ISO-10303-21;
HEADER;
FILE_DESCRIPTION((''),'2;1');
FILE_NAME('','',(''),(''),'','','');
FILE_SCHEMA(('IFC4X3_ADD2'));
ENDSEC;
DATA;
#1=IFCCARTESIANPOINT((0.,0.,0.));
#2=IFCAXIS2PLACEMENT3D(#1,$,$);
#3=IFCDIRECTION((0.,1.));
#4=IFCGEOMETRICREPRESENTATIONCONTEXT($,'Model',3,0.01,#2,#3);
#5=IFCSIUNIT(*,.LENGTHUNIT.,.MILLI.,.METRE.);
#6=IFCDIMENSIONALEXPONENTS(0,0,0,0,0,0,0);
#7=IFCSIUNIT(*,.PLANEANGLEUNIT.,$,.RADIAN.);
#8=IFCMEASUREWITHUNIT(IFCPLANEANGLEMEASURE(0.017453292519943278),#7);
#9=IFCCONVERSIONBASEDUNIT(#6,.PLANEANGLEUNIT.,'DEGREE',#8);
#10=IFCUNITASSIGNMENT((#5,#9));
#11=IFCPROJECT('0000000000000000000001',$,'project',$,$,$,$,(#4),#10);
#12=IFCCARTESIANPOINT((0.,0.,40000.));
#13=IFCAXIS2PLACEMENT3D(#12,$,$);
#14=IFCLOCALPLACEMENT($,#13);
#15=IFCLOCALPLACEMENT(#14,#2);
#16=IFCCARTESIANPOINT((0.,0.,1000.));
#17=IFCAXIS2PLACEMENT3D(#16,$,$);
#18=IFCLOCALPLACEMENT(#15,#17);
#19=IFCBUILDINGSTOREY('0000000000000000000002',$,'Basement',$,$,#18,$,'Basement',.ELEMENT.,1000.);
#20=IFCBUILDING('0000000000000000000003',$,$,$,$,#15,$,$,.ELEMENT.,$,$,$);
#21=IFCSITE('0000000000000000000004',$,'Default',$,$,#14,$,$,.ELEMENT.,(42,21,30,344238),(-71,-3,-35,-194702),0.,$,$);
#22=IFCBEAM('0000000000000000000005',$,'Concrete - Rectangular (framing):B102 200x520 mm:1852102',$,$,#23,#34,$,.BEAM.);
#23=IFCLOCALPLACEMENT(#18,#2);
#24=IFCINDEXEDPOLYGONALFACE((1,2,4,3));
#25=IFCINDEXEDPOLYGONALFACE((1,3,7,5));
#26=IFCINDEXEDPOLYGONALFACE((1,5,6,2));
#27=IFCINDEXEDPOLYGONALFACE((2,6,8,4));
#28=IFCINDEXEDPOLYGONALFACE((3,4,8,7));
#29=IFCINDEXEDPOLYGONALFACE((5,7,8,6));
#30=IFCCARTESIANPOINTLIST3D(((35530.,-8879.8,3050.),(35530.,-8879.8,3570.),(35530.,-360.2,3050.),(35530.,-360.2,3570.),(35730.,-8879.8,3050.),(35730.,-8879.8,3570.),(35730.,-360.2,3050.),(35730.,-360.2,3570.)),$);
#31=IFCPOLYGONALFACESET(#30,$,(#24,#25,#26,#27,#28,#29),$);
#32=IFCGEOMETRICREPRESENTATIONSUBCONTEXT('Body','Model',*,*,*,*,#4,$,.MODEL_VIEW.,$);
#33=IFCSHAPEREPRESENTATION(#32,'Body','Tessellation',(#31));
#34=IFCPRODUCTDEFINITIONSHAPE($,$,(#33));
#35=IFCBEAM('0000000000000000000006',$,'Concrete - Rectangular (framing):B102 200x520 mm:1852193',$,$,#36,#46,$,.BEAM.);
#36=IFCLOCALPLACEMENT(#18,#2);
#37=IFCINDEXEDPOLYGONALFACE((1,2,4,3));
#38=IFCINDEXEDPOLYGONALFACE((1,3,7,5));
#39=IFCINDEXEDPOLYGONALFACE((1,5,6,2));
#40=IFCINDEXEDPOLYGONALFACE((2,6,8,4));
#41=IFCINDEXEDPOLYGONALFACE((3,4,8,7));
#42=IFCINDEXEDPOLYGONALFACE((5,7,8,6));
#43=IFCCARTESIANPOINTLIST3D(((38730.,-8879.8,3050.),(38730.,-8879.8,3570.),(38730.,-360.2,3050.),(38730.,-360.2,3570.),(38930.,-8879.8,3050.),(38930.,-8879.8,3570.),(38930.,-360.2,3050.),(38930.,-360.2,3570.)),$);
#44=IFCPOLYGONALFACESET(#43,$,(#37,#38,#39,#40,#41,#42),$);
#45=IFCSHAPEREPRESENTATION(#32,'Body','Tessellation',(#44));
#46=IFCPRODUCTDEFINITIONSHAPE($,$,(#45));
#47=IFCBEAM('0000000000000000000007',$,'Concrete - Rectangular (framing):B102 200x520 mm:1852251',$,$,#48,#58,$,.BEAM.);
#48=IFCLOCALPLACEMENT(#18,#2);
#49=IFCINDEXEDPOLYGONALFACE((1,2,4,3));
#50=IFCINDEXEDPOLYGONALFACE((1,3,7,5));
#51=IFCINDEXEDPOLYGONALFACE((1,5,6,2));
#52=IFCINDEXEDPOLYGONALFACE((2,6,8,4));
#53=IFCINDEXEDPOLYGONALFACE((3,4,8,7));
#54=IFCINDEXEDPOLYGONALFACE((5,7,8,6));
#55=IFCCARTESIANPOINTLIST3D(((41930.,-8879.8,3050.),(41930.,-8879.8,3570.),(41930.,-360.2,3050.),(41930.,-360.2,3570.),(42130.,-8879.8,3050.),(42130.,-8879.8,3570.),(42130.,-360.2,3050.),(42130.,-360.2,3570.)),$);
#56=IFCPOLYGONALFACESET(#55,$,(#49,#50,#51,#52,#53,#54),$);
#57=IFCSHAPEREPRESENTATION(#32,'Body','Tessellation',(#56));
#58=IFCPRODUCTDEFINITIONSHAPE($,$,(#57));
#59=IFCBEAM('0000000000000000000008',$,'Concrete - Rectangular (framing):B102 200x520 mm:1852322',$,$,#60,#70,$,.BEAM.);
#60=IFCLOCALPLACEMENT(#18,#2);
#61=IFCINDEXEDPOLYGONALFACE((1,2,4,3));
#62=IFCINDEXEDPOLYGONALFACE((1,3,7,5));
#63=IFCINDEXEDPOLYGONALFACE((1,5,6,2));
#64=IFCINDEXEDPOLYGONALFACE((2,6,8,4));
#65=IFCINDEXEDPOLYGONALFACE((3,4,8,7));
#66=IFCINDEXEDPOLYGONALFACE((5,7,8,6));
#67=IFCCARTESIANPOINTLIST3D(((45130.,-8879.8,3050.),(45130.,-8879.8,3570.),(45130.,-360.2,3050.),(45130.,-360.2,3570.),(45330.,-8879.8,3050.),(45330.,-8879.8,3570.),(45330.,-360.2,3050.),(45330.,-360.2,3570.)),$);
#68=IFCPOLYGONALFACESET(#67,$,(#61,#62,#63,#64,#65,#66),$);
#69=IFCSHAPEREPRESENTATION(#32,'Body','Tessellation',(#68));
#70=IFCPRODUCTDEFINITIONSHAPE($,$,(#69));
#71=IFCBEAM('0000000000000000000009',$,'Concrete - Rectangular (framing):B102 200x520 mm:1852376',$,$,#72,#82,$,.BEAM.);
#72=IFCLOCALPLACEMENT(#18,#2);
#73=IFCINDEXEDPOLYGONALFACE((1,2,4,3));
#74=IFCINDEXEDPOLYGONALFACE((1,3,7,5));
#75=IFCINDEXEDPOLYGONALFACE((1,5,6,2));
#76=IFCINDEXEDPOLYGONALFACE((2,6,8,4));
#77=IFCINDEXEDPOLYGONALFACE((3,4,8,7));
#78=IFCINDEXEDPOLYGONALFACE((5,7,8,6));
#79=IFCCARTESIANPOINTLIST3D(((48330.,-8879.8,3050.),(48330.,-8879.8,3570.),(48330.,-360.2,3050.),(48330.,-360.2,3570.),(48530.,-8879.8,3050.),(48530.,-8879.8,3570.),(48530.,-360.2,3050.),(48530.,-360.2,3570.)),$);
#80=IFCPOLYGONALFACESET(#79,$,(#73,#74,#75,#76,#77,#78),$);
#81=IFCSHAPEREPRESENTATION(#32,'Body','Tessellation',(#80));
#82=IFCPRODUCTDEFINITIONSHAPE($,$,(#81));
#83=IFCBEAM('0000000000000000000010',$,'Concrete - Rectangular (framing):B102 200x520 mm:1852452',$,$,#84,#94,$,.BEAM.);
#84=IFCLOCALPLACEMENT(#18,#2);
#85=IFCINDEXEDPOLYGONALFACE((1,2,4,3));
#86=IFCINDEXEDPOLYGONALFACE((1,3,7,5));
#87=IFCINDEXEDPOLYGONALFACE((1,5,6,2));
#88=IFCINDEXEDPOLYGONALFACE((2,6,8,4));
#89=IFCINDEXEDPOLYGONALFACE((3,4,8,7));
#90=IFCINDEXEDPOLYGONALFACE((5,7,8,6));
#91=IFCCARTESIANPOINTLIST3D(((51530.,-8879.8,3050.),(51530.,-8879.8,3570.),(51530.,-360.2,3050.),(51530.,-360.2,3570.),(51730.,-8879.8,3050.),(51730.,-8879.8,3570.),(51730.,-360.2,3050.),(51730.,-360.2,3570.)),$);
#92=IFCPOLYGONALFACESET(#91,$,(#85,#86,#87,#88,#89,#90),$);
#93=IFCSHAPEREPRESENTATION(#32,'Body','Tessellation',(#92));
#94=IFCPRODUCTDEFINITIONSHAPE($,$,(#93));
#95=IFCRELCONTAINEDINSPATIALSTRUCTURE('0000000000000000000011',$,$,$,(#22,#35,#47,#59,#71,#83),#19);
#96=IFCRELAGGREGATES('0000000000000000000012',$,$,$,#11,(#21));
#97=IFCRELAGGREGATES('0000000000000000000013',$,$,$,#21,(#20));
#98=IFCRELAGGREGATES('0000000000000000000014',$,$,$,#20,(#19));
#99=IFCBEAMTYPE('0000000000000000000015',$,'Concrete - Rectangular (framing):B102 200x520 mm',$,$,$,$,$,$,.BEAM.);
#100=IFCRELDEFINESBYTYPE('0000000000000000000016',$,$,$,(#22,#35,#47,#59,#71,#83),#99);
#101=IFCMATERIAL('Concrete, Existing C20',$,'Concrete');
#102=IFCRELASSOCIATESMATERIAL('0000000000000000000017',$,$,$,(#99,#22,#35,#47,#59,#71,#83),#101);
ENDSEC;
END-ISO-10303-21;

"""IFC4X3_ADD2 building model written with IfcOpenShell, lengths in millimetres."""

from ifc_helpers import new_model, entity, si_unit, converted_unit, direction, frame, origin, origin_2d_with_axis, place, context, subcontext, project, spatial, rectangle, extrude, source, transform, mapped, material, material_profile, profile_set, profile_usage, type_object, type_shapes, element, save


model = new_model("IFC4X3_ADD2")

# Units and contexts
model_context = context("Model", 3, precision=0.01, world=origin(), true_north=direction((0.0, 1.0)))
body_context = subcontext(model_context, "Body", "Model", "MODEL_VIEW")
ifc_project = project(units=[si_unit("LENGTHUNIT", "METRE", prefix="MILLI"), converted_unit("PLANEANGLEUNIT", "DEGREE", entity("IfcPlaneAngleMeasure", 0.017453292519943278), si_unit("PLANEANGLEUNIT", "RADIAN"), dimensions=[0, 0, 0, 0, 0, 0, 0])], contexts=[model_context])

# Site, building, storey
site_placement = place(None, frame((0.0, 0.0, 40000.0)))
site = spatial("IfcSite", under=ifc_project, at=site_placement, Name="Default", CompositionType="ELEMENT", RefLatitude=(42, 21, 30, 344238), RefLongitude=(-71, -3, -35, -194702), RefElevation=0.0)
building_placement = place(site_placement, origin())
building = spatial("IfcBuilding", under=site, at=building_placement, CompositionType="ELEMENT")
storey_placement = place(building_placement, frame((0.0, 0.0, 1000.0)))
storey = spatial("IfcBuildingStorey", under=building, at=storey_placement, Name="Basement", LongName="Basement", CompositionType="ELEMENT", Elevation=1000.0)

# Shared definitions
ifc_material_1 = material(Name="Concrete, Existing C20", Category="Concrete")

# Beams
ifc_material_profile_1 = material_profile(ifc_material_1, rectangle(XDim=8519.8, YDim=200.0, at=origin_2d_with_axis()), Name="B102 200x520 mm")
ifc_profile_set_1 = profile_set([ifc_material_profile_1], Name="B102 200x520 mm")
ifc_profile_usage_1 = profile_usage(ifc_profile_set_1, cardinal=8)
beam_type_1 = type_object("IfcBeamType", Name="Concrete - Rectangular (framing):B102 200x520 mm", PredefinedType="BEAM", material=ifc_profile_set_1)
shared_shape_1 = source(origin(), body_context, "Body", "SweptSolid", [
    extrude(rectangle(XDim=8519.6, YDim=200.0, at=origin_2d_with_axis()), frame((0.0, 0.0, -260.0), z_axis=(0.0, 0.0, 1.0), x_axis=(-1.0, 0.0, 0.0)), (0.0, 0.0, 1.0), 520.0),
])
type_shapes(beam_type_1, [shared_shape_1])
for number, where, z_axis, x_axis, name in (
    (1, (35630.0, -4620.0, 3310.0), (0.0, 0.0, 1.0), (0.0, -1.0, 0.0), "Concrete - Rectangular (framing):B102 200x520 mm:1852102"),
    (2, (38830.0, -4620.0, 3310.0), (0.0, 0.0, 1.0), (0.0, -1.0, 0.0), "Concrete - Rectangular (framing):B102 200x520 mm:1852193"),
    (3, (42030.0, -4620.0, 3310.0), (0.0, 0.0, 1.0), (0.0, -1.0, 0.0), "Concrete - Rectangular (framing):B102 200x520 mm:1852251"),
    (4, (45230.0, -4620.0, 3310.0), (0.0, 0.0, 1.0), (0.0, -1.0, 0.0), "Concrete - Rectangular (framing):B102 200x520 mm:1852322"),
    (5, (48430.0, -4620.0, 3310.0), (0.0, 0.0, 1.0), (0.0, -1.0, 0.0), "Concrete - Rectangular (framing):B102 200x520 mm:1852376"),
    (6, (51630.0, -4620.0, 3310.0), (0.0, 0.0, 1.0), (0.0, -1.0, 0.0), "Concrete - Rectangular (framing):B102 200x520 mm:1852452"),
):
    element("IfcBeam", number, at=place(storey_placement, frame(where, z_axis=z_axis, x_axis=x_axis)), inside=storey, type_object=beam_type_1, material=ifc_profile_usage_1, Name=name, PredefinedType="BEAM", context=body_context, shape_type="MappedRepresentation", body=[
        mapped(shared_shape_1, transform((0.0, 0.0, 0.0), scale=1.0)),
    ])

save(model, "model.ifc")
